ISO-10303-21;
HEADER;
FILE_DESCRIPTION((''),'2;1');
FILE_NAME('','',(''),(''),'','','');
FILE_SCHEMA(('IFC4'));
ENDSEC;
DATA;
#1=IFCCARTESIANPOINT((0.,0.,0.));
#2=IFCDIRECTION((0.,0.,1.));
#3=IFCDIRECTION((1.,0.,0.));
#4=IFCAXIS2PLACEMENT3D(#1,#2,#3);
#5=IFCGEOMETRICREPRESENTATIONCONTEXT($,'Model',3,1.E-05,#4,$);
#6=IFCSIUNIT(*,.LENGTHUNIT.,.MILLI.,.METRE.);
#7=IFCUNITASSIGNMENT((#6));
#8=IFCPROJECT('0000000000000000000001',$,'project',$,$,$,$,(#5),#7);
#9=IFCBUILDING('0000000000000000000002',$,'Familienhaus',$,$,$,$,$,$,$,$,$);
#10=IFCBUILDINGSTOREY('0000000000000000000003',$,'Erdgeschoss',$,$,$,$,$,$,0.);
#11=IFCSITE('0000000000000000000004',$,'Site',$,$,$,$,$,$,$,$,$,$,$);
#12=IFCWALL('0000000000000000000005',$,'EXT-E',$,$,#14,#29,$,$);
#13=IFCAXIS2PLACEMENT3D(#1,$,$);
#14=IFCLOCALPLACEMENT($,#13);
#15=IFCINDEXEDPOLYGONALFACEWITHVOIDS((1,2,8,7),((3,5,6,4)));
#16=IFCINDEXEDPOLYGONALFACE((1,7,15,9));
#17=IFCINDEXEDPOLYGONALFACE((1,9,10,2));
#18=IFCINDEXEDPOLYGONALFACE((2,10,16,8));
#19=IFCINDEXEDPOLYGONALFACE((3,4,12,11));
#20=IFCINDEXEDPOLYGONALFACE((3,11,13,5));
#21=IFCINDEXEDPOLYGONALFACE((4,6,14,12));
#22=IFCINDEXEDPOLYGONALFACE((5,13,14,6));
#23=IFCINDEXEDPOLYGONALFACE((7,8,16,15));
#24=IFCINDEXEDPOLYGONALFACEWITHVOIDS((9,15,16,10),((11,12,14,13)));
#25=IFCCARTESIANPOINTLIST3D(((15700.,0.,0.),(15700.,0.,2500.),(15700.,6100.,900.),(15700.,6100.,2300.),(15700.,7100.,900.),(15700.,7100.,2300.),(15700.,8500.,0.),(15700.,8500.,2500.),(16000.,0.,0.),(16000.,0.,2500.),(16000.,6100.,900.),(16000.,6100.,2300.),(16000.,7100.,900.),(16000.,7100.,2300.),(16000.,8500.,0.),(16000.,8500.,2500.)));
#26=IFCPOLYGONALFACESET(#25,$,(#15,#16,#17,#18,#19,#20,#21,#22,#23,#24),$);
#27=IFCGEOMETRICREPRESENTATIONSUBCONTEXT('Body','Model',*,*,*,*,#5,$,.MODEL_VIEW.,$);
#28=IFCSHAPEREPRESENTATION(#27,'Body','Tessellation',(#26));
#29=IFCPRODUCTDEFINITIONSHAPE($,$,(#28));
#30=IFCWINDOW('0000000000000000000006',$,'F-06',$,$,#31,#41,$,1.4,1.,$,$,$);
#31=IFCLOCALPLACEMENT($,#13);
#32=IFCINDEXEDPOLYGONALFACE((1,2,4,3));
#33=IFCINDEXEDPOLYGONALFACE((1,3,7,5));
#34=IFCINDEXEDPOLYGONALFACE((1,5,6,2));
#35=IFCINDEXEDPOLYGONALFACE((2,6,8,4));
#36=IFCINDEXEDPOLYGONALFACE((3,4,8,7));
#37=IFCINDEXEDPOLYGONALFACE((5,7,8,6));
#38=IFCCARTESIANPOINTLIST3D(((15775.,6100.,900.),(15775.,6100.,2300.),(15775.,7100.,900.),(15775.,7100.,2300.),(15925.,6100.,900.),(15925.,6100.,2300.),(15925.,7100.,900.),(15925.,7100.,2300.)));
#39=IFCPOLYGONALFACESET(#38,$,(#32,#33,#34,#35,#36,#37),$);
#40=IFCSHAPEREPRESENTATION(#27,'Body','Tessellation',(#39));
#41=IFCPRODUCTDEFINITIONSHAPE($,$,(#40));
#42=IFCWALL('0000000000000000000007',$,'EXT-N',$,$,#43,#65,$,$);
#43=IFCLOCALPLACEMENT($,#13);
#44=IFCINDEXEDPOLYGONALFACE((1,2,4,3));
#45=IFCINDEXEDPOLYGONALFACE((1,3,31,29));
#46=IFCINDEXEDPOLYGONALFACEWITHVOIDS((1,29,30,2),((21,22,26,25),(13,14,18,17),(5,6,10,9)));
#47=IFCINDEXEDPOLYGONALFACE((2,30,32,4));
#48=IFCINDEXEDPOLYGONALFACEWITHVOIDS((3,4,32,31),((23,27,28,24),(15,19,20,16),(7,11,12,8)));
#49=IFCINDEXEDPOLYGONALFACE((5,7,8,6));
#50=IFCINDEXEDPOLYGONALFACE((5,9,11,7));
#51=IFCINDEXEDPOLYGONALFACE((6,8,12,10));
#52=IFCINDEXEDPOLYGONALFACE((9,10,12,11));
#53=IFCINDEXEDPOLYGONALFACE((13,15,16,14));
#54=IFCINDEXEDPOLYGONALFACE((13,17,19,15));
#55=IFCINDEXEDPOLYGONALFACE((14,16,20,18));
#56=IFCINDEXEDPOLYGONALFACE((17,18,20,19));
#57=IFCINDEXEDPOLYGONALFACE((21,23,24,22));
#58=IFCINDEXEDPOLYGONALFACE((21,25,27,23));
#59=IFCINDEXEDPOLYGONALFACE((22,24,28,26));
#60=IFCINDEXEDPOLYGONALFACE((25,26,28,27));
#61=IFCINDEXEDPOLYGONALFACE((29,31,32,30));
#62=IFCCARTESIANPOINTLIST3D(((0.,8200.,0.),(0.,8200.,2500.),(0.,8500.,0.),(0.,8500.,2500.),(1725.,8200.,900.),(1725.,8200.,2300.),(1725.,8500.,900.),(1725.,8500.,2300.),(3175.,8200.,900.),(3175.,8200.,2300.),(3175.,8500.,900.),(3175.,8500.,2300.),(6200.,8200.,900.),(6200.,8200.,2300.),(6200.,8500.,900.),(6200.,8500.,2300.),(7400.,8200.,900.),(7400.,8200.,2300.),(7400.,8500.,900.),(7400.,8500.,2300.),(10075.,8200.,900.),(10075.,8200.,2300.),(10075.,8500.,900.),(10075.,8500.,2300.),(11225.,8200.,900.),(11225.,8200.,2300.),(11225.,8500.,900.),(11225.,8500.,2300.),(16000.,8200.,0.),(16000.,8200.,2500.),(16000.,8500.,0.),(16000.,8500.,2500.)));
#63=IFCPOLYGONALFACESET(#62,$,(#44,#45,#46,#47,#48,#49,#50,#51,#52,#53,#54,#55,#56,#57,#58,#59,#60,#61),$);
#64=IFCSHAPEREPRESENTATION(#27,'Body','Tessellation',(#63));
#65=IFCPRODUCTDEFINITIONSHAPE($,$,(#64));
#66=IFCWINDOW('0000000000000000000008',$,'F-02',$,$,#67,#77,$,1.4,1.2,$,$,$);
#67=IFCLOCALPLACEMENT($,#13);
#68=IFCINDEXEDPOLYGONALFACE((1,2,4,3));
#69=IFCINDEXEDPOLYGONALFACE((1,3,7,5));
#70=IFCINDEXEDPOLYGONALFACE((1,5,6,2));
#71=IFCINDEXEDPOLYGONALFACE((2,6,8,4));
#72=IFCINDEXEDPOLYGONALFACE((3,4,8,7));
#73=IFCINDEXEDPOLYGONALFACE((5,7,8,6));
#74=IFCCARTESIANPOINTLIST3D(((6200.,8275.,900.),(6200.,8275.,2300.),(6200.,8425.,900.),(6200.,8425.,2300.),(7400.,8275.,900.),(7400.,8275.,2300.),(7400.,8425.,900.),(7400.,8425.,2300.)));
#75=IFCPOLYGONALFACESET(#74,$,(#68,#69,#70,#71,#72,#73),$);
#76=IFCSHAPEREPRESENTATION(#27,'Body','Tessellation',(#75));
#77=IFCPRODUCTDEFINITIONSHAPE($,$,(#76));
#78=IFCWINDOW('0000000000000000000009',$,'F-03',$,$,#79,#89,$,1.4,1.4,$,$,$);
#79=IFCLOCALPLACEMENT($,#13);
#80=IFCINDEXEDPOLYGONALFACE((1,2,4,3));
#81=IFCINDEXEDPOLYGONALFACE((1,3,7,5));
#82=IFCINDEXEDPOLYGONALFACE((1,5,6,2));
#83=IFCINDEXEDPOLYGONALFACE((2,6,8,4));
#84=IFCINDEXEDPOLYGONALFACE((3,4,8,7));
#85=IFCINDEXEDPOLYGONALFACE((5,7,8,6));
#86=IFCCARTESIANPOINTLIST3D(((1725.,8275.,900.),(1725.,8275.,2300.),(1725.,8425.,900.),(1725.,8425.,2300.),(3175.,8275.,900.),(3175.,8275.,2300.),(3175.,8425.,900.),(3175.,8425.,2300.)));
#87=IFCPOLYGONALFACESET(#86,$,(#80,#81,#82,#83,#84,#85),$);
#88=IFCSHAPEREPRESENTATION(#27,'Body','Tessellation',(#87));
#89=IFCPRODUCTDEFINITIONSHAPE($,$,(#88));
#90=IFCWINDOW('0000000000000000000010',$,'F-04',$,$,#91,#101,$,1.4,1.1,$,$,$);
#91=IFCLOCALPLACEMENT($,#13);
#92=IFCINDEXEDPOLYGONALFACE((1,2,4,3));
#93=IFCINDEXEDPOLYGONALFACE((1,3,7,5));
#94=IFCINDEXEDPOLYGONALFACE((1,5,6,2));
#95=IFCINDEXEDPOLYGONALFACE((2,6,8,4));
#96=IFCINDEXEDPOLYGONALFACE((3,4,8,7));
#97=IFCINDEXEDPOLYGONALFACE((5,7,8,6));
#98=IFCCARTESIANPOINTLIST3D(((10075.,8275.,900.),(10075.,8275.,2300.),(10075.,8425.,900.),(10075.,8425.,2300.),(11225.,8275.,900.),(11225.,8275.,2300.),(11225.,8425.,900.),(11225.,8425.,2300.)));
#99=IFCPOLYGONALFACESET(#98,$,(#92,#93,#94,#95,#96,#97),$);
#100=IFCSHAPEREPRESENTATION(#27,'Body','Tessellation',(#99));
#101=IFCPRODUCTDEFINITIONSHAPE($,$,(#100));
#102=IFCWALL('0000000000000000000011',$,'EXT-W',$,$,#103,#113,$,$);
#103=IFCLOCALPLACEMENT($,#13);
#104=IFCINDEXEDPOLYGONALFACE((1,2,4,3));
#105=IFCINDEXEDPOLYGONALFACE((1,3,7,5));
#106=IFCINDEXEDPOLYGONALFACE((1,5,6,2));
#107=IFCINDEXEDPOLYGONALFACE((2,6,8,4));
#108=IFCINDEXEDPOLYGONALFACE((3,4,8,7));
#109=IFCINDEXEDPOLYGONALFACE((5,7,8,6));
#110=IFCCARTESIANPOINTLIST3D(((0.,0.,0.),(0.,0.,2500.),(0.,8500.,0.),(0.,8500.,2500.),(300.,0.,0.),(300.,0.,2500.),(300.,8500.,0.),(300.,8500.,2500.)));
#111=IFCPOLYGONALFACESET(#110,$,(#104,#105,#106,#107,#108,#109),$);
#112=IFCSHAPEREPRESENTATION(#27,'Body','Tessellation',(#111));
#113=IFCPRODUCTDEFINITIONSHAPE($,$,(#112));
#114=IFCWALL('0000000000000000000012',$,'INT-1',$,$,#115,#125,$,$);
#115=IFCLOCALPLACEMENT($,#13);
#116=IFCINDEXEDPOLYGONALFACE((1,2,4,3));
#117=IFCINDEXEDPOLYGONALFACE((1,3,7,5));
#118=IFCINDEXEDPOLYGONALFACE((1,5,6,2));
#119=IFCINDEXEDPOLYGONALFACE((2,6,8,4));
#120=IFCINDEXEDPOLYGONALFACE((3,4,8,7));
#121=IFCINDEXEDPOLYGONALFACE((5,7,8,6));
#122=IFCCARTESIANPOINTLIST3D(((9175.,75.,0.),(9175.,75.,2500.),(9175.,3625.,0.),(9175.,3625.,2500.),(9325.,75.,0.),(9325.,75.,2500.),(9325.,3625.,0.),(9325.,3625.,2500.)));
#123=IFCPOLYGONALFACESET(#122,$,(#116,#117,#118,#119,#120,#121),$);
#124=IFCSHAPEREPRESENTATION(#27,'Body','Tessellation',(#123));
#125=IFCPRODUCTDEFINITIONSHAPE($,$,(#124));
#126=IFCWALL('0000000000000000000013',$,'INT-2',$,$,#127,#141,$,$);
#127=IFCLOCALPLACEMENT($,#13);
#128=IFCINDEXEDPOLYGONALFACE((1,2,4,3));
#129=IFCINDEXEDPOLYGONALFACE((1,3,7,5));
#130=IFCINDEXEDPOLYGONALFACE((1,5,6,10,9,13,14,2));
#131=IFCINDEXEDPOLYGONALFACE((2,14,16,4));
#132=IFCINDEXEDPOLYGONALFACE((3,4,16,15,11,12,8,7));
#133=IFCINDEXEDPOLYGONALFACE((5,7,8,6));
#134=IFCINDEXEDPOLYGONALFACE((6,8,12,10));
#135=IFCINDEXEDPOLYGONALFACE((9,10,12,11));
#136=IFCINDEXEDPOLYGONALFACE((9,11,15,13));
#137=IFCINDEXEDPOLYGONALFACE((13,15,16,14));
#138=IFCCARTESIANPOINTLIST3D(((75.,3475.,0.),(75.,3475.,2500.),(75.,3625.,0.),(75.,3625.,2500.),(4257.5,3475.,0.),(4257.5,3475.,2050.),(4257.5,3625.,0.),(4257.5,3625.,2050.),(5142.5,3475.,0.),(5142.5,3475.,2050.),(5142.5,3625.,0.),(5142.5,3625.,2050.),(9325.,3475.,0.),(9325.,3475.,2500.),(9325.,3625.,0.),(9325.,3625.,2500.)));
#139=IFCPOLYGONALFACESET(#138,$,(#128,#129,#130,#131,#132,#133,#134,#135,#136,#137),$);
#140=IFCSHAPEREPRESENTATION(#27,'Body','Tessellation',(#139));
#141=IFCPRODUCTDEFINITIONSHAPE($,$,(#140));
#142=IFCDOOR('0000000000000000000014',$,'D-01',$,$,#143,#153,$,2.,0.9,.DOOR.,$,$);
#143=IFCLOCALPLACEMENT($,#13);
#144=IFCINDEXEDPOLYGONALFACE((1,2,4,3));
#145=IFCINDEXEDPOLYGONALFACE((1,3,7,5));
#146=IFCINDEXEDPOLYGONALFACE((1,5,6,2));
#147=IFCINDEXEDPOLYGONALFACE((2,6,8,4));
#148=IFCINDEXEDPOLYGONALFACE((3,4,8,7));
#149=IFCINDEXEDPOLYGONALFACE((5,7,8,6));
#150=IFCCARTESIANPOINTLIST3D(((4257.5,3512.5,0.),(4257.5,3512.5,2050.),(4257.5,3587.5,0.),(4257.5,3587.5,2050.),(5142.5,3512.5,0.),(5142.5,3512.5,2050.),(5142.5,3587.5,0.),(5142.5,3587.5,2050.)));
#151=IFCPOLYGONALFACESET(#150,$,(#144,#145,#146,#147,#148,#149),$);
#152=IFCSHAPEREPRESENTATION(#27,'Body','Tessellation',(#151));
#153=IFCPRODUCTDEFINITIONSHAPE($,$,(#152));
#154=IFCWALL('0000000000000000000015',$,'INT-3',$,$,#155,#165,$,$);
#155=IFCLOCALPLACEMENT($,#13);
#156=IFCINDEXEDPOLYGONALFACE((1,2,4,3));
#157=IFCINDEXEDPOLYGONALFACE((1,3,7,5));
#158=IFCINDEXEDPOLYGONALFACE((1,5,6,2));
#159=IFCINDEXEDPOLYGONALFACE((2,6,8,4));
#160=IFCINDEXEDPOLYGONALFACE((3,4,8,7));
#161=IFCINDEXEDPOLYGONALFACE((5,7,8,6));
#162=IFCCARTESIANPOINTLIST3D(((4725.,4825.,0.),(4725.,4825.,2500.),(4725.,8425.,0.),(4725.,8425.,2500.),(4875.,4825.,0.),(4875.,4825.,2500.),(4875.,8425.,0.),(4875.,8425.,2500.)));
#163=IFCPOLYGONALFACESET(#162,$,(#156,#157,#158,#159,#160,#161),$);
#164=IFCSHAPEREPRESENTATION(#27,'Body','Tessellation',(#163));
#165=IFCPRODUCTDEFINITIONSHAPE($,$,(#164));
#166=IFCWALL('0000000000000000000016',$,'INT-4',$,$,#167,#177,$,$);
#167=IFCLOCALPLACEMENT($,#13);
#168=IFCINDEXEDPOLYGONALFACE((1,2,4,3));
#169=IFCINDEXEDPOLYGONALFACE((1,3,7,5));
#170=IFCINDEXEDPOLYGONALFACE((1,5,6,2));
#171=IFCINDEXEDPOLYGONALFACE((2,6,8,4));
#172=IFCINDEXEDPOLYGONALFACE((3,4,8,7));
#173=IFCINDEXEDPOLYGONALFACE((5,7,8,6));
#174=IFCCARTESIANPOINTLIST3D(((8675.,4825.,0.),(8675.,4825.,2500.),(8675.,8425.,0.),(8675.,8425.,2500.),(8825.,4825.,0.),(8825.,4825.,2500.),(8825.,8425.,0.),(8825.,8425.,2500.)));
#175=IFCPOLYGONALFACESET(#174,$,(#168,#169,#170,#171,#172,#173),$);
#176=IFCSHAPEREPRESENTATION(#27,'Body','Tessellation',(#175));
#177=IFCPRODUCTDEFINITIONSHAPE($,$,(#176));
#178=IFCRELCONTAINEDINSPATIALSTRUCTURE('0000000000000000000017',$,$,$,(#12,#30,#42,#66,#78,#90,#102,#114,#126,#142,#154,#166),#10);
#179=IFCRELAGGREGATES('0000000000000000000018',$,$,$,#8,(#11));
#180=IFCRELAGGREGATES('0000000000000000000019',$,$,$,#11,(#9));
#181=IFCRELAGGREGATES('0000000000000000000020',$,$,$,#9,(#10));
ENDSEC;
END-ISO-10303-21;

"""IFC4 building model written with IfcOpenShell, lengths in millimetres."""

from ifc_helpers import new_model, si_unit, frame, origin_with_axes, place, context, subcontext, project, spatial, indexed_curve, outline, extrude, element, fill, save


model = new_model("IFC4")

# Units and contexts
model_context = context("Model", 3, precision=1e-05, world=origin_with_axes())
body_context = subcontext(model_context, "Body", "Model", "MODEL_VIEW")
ifc_project = project(units=[si_unit("LENGTHUNIT", "METRE", prefix="MILLI")], contexts=[model_context])

# Site, building, storey
site = spatial("IfcSite", under=ifc_project, Name="Site")
building = spatial("IfcBuilding", under=site, Name="Familienhaus")
storey = spatial("IfcBuildingStorey", under=building, Name="Erdgeschoss", Elevation=0.0)

# Wall, opening, window
wall_1_placement = place(None, origin_with_axes())
wall_1 = element("IfcWall", 1, at=wall_1_placement, inside=storey, Name="EXT-E", context=body_context, shape_type="SweptSolid", body=[
    extrude(outline(indexed_curve([(15700.0, 0.0), (15700.0, 8500.0), (16000.0, 8500.0), (16000.0, 0.0), (15700.0, 0.0)])), origin_with_axes(), (0.0, 0.0, 1.0), 2500.0),
])
opening_1_placement = place(wall_1_placement, frame((0.0, 0.0, 900.0), z_axis=(0.0, 0.0, 1.0), x_axis=(1.0, 0.0, 0.0)))
opening_1 = element("IfcOpeningElement", 2, at=opening_1_placement, cuts=wall_1, context=body_context, shape_type="SweptSolid", body=[
    extrude(outline(indexed_curve([(15680.0, 6100.0), (15680.0, 7100.0), (16020.0, 7100.0), (16020.0, 6100.0), (15680.0, 6100.0)])), origin_with_axes(), (0.0, 0.0, 1.0), 1400.0),
])
window_1_placement = place(opening_1_placement, origin_with_axes())
window_1 = element("IfcWindow", 3, at=window_1_placement, inside=storey, Name="F-06", OverallHeight=1.4, OverallWidth=1.0, context=body_context, shape_type="SweptSolid", body=[
    extrude(outline(indexed_curve([(15775.0, 6100.0), (15775.0, 7100.0), (15925.0, 7100.0), (15925.0, 6100.0), (15775.0, 6100.0)])), origin_with_axes(), (0.0, 0.0, 1.0), 1400.0),
])
fill(opening_1, window_1)

# Wall, openings, windows
wall_2_placement = place(None, origin_with_axes())
wall_2 = element("IfcWall", 4, at=wall_2_placement, inside=storey, Name="EXT-N", context=body_context, shape_type="SweptSolid", body=[
    extrude(outline(indexed_curve([(16000.0, 8200.0), (0.0, 8200.0), (0.0, 8500.0), (16000.0, 8500.0), (16000.0, 8200.0)])), origin_with_axes(), (0.0, 0.0, 1.0), 2500.0),
])
opening_2_placement = place(wall_2_placement, frame((0.0, 0.0, 900.0), z_axis=(0.0, 0.0, 1.0), x_axis=(1.0, 0.0, 0.0)))
opening_2 = element("IfcOpeningElement", 5, at=opening_2_placement, cuts=wall_2, context=body_context, shape_type="SweptSolid", body=[
    extrude(outline(indexed_curve([(7400.0, 8180.0), (6200.0, 8180.0), (6200.0, 8520.0), (7400.0, 8520.0), (7400.0, 8180.0)])), origin_with_axes(), (0.0, 0.0, 1.0), 1400.0),
])
opening_3_placement = place(wall_2_placement, frame((0.0, 0.0, 900.0), z_axis=(0.0, 0.0, 1.0), x_axis=(1.0, 0.0, 0.0)))
opening_3 = element("IfcOpeningElement", 6, at=opening_3_placement, cuts=wall_2, context=body_context, shape_type="SweptSolid", body=[
    extrude(outline(indexed_curve([(3175.0, 8180.0), (1725.0, 8180.0), (1725.0, 8520.0), (3175.0, 8520.0), (3175.0, 8180.0)])), origin_with_axes(), (0.0, 0.0, 1.0), 1400.0),
])
opening_4_placement = place(wall_2_placement, frame((0.0, 0.0, 900.0), z_axis=(0.0, 0.0, 1.0), x_axis=(1.0, 0.0, 0.0)))
opening_4 = element("IfcOpeningElement", 7, at=opening_4_placement, cuts=wall_2, context=body_context, shape_type="SweptSolid", body=[
    extrude(outline(indexed_curve([(11225.0, 8180.0), (10075.0, 8180.0), (10075.0, 8520.0), (11225.0, 8520.0), (11225.0, 8180.0)])), origin_with_axes(), (0.0, 0.0, 1.0), 1400.0),
])
window_2_placement = place(opening_2_placement, origin_with_axes())
window_2 = element("IfcWindow", 8, at=window_2_placement, inside=storey, Name="F-02", OverallHeight=1.4, OverallWidth=1.2, context=body_context, shape_type="SweptSolid", body=[
    extrude(outline(indexed_curve([(7400.0, 8275.0), (6200.0, 8275.0), (6200.0, 8425.0), (7400.0, 8425.0), (7400.0, 8275.0)])), origin_with_axes(), (0.0, 0.0, 1.0), 1400.0),
])
fill(opening_2, window_2)
window_3_placement = place(opening_3_placement, origin_with_axes())
window_3 = element("IfcWindow", 9, at=window_3_placement, inside=storey, Name="F-03", OverallHeight=1.4, OverallWidth=1.4, context=body_context, shape_type="SweptSolid", body=[
    extrude(outline(indexed_curve([(3175.0, 8275.0), (1725.0, 8275.0), (1725.0, 8425.0), (3175.0, 8425.0), (3175.0, 8275.0)])), origin_with_axes(), (0.0, 0.0, 1.0), 1400.0),
])
fill(opening_3, window_3)
window_4_placement = place(opening_4_placement, origin_with_axes())
window_4 = element("IfcWindow", 10, at=window_4_placement, inside=storey, Name="F-04", OverallHeight=1.4, OverallWidth=1.1, context=body_context, shape_type="SweptSolid", body=[
    extrude(outline(indexed_curve([(11225.0, 8275.0), (10075.0, 8275.0), (10075.0, 8425.0), (11225.0, 8425.0), (11225.0, 8275.0)])), origin_with_axes(), (0.0, 0.0, 1.0), 1400.0),
])
fill(opening_4, window_4)

# Walls
wall_3_placement = place(None, origin_with_axes())
element("IfcWall", 11, at=wall_3_placement, inside=storey, Name="EXT-W", context=body_context, shape_type="SweptSolid", body=[
    extrude(outline(indexed_curve([(300.0, 8500.0), (300.0, 0.0), (0.0, 0.0), (0.0, 8500.0), (300.0, 8500.0)])), origin_with_axes(), (0.0, 0.0, 1.0), 2500.0),
])
wall_4_placement = place(None, origin_with_axes())
element("IfcWall", 12, at=wall_4_placement, inside=storey, Name="INT-1", context=body_context, shape_type="SweptSolid", body=[
    extrude(outline(indexed_curve([(9175.0, 75.0), (9175.0, 3625.0), (9325.0, 3625.0), (9325.0, 75.0), (9175.0, 75.0)])), origin_with_axes(), (0.0, 0.0, 1.0), 2500.0),
])

# Wall, opening, door
wall_5_placement = place(None, origin_with_axes())
wall_5 = element("IfcWall", 13, at=wall_5_placement, inside=storey, Name="INT-2", context=body_context, shape_type="SweptSolid", body=[
    extrude(outline(indexed_curve([(75.0, 3625.0), (9325.0, 3625.0), (9325.0, 3475.0), (75.0, 3475.0), (75.0, 3625.0)])), origin_with_axes(), (0.0, 0.0, 1.0), 2500.0),
])
opening_5_placement = place(wall_5_placement, origin_with_axes())
opening_5 = element("IfcOpeningElement", 14, at=opening_5_placement, cuts=wall_5, context=body_context, shape_type="SweptSolid", body=[
    extrude(outline(indexed_curve([(4257.5, 3645.0), (5142.5, 3645.0), (5142.5, 3455.0), (4257.5, 3455.0), (4257.5, 3645.0)])), origin_with_axes(), (0.0, 0.0, 1.0), 2050.0),
])
door_1_placement = place(opening_5_placement, origin_with_axes())
door_1 = element("IfcDoor", 15, at=door_1_placement, inside=storey, Name="D-01", OverallHeight=2.0, OverallWidth=0.9, PredefinedType="DOOR", context=body_context, shape_type="SweptSolid", body=[
    extrude(outline(indexed_curve([(4257.5, 3587.5), (5142.5, 3587.5), (5142.5, 3512.5), (4257.5, 3512.5), (4257.5, 3587.5)])), origin_with_axes(), (0.0, 0.0, 1.0), 2050.0),
])
fill(opening_5, door_1)

# Walls
wall_6_placement = place(None, origin_with_axes())
element("IfcWall", 16, at=wall_6_placement, inside=storey, Name="INT-3", context=body_context, shape_type="SweptSolid", body=[
    extrude(outline(indexed_curve([(4725.0, 4825.0), (4725.0, 8425.0), (4875.0, 8425.0), (4875.0, 4825.0), (4725.0, 4825.0)])), origin_with_axes(), (0.0, 0.0, 1.0), 2500.0),
])
wall_7_placement = place(None, origin_with_axes())
element("IfcWall", 17, at=wall_7_placement, inside=storey, Name="INT-4", context=body_context, shape_type="SweptSolid", body=[
    extrude(outline(indexed_curve([(8675.0, 4825.0), (8675.0, 8425.0), (8825.0, 8425.0), (8825.0, 4825.0), (8675.0, 4825.0)])), origin_with_axes(), (0.0, 0.0, 1.0), 2500.0),
])

save(model, "model.ifc")
